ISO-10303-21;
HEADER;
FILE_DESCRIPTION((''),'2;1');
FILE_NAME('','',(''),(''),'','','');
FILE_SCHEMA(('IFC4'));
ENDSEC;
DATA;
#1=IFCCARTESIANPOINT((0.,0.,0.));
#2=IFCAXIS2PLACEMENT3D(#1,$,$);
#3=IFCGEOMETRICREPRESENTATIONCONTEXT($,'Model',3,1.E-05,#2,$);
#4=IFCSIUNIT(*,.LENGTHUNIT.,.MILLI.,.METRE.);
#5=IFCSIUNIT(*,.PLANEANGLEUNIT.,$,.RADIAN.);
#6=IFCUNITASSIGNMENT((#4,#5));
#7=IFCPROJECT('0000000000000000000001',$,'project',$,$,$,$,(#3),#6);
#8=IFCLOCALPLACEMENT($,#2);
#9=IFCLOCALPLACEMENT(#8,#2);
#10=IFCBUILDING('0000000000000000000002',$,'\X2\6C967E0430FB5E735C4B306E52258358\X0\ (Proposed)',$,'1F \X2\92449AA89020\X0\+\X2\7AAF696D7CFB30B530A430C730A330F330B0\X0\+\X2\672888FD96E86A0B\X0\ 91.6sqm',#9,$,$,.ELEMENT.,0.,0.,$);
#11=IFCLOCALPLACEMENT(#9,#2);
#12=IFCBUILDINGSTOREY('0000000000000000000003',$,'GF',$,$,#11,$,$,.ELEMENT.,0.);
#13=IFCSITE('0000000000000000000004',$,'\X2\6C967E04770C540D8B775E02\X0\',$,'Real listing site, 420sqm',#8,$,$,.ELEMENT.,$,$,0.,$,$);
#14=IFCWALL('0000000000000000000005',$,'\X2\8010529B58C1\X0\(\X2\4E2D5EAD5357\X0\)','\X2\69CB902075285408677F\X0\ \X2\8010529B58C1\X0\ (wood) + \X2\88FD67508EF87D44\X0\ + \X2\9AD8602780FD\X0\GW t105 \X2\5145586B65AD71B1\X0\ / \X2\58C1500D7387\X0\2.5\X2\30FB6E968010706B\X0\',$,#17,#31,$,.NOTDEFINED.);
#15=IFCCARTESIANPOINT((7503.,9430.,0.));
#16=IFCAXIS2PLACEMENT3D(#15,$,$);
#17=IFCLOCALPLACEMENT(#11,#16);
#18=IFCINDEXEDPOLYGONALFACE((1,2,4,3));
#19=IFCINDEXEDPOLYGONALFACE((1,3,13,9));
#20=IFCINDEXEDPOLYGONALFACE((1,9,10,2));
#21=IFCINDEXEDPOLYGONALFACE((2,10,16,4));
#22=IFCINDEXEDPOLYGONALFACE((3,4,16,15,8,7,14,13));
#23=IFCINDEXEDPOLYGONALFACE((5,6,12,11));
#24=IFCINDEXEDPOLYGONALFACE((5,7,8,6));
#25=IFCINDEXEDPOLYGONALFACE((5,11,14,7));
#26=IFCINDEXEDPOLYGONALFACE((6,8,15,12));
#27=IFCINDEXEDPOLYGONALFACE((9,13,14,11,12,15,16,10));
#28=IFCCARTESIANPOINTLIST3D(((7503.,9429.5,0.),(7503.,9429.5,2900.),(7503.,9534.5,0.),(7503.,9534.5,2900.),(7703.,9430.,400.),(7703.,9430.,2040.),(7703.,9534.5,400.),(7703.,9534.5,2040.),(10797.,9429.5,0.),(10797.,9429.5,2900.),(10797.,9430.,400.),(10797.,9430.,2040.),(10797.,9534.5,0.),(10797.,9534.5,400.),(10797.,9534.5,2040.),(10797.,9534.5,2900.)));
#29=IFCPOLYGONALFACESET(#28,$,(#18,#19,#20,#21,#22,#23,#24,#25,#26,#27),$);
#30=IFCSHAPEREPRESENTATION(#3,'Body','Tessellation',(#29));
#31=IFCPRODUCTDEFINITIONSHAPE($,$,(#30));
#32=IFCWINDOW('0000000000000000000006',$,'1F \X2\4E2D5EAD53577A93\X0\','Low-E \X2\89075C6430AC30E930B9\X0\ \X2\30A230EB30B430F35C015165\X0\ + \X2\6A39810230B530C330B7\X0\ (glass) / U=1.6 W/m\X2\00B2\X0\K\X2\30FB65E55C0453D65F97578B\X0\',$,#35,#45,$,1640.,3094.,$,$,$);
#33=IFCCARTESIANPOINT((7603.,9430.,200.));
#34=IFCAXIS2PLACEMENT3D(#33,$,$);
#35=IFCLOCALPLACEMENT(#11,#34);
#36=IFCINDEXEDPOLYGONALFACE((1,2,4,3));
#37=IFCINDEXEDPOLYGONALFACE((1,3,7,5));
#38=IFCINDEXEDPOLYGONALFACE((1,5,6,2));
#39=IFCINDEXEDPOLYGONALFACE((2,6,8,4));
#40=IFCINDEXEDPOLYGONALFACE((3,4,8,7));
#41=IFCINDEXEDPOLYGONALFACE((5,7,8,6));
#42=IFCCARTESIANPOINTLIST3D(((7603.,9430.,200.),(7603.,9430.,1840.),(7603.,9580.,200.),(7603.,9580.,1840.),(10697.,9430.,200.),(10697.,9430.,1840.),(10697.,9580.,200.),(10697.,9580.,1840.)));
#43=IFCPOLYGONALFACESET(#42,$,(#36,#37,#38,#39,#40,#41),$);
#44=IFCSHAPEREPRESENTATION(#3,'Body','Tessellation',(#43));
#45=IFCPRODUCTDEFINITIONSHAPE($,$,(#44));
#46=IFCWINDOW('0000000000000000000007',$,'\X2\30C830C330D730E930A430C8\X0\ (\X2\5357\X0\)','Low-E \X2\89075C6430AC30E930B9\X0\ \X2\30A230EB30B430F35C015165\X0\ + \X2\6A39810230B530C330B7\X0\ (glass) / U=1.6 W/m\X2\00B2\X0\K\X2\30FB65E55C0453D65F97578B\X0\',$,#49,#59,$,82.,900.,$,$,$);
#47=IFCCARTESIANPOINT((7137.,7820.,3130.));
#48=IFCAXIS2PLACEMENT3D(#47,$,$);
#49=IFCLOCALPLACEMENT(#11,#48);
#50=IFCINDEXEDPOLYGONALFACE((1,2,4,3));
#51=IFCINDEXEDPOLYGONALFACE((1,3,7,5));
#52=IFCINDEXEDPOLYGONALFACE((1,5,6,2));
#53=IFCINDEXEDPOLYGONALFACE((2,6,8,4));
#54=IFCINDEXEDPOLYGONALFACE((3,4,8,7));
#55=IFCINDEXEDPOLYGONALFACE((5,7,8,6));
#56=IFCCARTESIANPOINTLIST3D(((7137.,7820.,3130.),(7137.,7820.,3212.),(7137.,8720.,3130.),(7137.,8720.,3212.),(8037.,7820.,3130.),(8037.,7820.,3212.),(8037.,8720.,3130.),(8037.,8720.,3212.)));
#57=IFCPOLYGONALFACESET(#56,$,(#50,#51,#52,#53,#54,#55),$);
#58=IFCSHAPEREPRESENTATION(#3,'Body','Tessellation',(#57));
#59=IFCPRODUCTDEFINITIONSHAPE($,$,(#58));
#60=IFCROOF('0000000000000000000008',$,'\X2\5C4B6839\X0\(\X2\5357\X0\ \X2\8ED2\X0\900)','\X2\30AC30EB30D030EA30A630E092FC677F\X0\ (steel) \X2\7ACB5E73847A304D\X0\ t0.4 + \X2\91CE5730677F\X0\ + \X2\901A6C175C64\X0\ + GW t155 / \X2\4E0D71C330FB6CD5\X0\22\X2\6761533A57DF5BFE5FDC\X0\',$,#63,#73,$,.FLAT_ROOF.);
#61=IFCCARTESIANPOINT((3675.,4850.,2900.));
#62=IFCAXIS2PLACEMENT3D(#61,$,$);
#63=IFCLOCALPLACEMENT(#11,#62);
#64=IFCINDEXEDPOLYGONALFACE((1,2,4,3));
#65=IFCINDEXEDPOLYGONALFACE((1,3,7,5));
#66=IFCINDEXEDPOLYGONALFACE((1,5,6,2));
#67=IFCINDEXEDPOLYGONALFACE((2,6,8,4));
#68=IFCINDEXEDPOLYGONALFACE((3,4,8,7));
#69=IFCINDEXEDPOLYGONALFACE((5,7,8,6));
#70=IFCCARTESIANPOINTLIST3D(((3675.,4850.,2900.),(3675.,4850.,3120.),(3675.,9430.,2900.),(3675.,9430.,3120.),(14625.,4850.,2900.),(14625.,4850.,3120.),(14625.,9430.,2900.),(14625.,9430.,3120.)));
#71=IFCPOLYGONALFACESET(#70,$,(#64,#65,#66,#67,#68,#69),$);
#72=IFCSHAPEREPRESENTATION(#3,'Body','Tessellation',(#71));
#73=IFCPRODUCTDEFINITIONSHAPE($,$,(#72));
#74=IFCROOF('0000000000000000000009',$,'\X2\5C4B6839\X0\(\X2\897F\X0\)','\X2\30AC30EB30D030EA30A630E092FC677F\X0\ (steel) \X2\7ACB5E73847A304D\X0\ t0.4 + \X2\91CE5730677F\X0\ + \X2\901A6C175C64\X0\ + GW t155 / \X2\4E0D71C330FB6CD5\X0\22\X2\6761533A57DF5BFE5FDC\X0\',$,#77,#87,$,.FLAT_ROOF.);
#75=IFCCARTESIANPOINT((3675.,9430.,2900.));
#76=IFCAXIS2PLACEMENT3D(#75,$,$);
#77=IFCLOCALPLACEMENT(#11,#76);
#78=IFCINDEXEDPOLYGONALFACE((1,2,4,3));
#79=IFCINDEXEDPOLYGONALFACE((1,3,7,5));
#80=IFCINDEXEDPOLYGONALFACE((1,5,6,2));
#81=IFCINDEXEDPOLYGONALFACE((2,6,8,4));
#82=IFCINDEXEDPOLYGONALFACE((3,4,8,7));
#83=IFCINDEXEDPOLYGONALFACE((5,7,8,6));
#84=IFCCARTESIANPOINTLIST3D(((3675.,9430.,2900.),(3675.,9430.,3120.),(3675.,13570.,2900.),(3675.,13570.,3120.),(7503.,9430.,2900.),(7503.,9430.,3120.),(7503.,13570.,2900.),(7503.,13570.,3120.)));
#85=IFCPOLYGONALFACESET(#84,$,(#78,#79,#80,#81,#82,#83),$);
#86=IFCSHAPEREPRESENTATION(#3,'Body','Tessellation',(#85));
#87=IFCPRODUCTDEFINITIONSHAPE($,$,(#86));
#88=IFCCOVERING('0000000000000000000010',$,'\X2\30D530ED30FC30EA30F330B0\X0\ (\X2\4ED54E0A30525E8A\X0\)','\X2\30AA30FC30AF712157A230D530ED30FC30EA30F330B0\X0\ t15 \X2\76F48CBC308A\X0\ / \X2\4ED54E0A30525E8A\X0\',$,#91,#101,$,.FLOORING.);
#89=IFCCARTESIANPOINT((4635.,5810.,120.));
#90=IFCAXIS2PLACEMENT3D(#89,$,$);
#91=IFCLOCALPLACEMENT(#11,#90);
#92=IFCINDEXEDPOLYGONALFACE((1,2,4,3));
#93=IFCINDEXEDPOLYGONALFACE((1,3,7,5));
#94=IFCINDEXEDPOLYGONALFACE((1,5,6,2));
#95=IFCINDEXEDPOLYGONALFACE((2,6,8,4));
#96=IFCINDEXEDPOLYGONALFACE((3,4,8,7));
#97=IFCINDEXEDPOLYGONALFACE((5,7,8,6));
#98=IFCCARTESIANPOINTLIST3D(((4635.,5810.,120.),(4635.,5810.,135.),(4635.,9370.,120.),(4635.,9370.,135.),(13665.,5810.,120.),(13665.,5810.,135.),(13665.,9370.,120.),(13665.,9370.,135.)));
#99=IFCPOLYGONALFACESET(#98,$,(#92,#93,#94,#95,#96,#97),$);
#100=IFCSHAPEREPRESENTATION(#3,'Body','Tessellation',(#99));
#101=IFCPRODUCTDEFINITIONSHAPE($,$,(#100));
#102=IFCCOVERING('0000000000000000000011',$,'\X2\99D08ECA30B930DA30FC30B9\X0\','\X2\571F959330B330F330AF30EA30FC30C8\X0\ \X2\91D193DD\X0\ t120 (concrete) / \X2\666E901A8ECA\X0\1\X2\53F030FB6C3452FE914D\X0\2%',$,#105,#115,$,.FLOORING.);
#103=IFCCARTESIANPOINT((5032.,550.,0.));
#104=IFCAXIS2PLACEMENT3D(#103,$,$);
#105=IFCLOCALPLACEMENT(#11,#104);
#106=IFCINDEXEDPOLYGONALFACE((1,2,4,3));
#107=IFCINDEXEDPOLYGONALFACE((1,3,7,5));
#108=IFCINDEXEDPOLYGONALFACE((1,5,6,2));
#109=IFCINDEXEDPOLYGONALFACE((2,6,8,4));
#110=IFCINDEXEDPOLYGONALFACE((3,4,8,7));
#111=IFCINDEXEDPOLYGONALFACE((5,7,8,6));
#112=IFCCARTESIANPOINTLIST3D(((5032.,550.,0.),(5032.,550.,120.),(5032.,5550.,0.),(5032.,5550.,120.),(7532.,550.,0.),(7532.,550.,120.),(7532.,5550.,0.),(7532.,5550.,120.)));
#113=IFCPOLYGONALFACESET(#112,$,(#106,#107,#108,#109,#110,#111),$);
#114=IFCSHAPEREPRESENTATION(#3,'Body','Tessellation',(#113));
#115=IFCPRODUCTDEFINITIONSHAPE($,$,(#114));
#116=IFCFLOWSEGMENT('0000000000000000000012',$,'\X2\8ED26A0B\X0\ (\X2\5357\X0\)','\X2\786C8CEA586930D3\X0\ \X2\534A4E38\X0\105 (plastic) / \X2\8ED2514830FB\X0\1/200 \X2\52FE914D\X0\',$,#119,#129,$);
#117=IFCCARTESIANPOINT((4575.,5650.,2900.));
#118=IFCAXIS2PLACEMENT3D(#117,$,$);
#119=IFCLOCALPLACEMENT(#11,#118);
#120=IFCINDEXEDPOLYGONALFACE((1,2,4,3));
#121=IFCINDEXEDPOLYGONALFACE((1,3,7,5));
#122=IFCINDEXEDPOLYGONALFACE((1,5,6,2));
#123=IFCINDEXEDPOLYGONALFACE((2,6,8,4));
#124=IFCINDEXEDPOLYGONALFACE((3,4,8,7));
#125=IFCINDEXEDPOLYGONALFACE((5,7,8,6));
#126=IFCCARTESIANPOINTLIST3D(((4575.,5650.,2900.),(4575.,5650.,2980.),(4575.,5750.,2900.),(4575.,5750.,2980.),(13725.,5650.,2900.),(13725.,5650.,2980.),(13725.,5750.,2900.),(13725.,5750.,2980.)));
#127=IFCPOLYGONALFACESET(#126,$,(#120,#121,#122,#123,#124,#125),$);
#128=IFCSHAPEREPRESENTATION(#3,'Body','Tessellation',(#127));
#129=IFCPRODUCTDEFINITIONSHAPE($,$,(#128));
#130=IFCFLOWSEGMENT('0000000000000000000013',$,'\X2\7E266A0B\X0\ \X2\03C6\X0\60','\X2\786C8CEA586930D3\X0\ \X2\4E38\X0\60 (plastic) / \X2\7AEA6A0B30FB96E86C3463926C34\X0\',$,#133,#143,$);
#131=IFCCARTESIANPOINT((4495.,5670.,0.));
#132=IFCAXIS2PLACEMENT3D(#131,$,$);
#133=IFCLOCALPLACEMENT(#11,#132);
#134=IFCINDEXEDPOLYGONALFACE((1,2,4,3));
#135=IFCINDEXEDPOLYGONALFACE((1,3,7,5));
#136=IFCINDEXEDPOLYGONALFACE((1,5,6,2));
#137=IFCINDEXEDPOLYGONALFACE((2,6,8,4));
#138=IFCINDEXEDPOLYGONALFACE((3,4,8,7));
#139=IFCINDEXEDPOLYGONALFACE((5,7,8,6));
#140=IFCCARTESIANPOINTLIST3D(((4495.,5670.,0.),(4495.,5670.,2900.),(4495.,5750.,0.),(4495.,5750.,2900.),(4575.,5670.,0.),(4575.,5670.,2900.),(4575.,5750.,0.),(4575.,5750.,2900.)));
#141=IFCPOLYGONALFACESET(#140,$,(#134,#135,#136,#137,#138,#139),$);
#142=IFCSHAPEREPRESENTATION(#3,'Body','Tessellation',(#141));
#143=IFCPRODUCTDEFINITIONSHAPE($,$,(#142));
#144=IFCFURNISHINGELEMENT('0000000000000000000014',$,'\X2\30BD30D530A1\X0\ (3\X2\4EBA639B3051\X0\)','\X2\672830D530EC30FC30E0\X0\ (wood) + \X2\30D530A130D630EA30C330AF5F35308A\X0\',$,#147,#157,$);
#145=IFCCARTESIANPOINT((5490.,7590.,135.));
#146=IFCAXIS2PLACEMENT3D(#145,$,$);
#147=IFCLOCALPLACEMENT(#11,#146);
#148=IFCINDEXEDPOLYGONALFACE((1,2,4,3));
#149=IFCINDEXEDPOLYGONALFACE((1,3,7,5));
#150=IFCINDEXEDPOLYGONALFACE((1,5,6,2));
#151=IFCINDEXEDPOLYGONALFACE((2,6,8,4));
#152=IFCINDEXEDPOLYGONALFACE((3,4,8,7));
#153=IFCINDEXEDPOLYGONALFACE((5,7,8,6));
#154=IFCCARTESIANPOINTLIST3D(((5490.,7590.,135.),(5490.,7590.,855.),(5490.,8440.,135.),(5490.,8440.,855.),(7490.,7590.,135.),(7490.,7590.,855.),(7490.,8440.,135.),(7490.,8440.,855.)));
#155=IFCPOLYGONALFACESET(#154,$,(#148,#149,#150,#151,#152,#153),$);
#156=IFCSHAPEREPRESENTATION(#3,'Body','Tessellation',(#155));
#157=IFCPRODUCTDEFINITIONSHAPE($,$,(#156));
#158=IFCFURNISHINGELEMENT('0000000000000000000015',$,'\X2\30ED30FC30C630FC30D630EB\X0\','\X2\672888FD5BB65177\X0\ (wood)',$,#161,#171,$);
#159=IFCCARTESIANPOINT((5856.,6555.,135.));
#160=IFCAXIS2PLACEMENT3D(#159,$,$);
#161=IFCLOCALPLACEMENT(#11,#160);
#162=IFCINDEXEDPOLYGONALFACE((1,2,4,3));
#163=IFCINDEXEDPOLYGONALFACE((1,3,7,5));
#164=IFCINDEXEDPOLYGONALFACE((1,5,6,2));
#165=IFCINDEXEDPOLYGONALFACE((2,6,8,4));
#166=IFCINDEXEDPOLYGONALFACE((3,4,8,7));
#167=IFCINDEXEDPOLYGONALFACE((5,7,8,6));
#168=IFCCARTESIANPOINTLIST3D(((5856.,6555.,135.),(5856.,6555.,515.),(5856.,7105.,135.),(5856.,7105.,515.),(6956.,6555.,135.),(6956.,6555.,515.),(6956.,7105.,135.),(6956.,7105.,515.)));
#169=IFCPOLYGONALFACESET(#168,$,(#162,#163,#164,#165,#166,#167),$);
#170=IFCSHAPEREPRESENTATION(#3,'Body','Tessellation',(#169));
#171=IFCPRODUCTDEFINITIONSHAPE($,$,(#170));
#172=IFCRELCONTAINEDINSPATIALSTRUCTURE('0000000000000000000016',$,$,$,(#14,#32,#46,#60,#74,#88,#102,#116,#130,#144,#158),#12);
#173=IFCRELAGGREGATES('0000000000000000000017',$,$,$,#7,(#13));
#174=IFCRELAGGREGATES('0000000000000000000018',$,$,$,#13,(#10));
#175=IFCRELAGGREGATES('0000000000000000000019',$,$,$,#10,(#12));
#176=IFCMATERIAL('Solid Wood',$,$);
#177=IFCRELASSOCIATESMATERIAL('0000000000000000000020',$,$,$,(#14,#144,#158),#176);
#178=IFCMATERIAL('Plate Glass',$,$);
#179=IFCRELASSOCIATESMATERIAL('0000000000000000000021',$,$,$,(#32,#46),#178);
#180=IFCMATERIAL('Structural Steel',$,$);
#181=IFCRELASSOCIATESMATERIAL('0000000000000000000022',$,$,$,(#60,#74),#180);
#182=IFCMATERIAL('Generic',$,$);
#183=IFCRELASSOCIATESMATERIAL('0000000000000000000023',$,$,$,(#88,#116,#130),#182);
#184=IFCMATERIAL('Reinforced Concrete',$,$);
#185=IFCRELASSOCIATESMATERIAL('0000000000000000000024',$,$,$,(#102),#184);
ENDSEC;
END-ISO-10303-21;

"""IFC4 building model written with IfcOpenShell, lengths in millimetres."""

from ifc_helpers import new_model, si_unit, frame, frame_2d, origin, place, context, project, spatial, rectangle, extrude, material, element, fill, save


model = new_model("IFC4")

# Units and contexts
model_context = context("Model", 3, precision=1e-05, world=origin())
ifc_project = project(units=[si_unit("LENGTHUNIT", "METRE", prefix="MILLI"), si_unit("PLANEANGLEUNIT", "RADIAN")], contexts=[model_context])

# Site, building, storey
site_placement = place(None, origin())
site = spatial("IfcSite", under=ifc_project, at=site_placement, Name="沖縄県名護市", ObjectType="Real listing site, 420sqm", CompositionType="ELEMENT", RefElevation=0.0)
building_placement = place(site_placement, origin())
building = spatial("IfcBuilding", under=site, at=building_placement, Name="沖縄・平屋の別荘 (Proposed)", ObjectType="1F 鉄骨造+窯業系サイディング+木製雨樋 91.6sqm", CompositionType="ELEMENT", ElevationOfRefHeight=0.0, ElevationOfTerrain=0.0)
storey_placement = place(building_placement, origin())
storey = spatial("IfcBuildingStorey", under=building, at=storey_placement, Name="GF", CompositionType="ELEMENT", Elevation=0.0)

# Shared definitions
ifc_material_1 = material(Name="Solid Wood")

# Shared definitions
ifc_material_2 = material(Name="Reinforced Concrete")

# Shared definitions
ifc_material_3 = material(Name="Plate Glass")

# Wall, opening, window
wall_1_placement = place(storey_placement, frame((7503.0, 9430.0, 0.0)))
wall_1 = element("IfcWall", 1, at=wall_1_placement, inside=storey, material=ifc_material_1, Name="耐力壁(中庭南)", Description="構造用合板 耐力壁 (wood) + 製材軸組 + 高性能GW t105 充填断熱 / 壁倍率2.5・準耐火", PredefinedType="NOTDEFINED", context=model_context, shape_type="SweptSolid", body=[
    extrude(rectangle(XDim=3294.0, YDim=105.0, at=frame_2d((1647.0, 52.0))), frame((7503.0, 9430.0, 0.0)), (0.0, 0.0, 1.0), 2900.0),
])
opening_1_placement = place(storey_placement, frame((7603.0, 9430.0, 200.0)))
opening_1 = element("IfcOpeningElement", 2, at=opening_1_placement, cuts=wall_1, PredefinedType="NOTDEFINED", context=model_context, shape_type="SweptSolid", body=[
    extrude(rectangle(XDim=3094.0, YDim=150.0, at=frame_2d((1547.0, 75.0))), frame((7603.0, 9430.0, 200.0)), (0.0, 0.0, 1.0), 1640.0),
])
window_1_placement = place(storey_placement, frame((7603.0, 9430.0, 200.0)))
window_1 = element("IfcWindow", 3, at=window_1_placement, inside=storey, material=ifc_material_3, Name="1F 中庭南窓", Description="Low-E 複層ガラス アルゴン封入 + 樹脂サッシ (glass) / U=1.6 W/m²K・日射取得型", OverallHeight=1640.0, OverallWidth=3094.0, context=model_context, shape_type="SweptSolid", body=[
    extrude(rectangle(XDim=3094.0, YDim=150.0, at=frame_2d((1547.0, 75.0))), frame((7603.0, 9430.0, 200.0)), (0.0, 0.0, 1.0), 1640.0),
])
fill(opening_1, window_1)

# Window
window_2_placement = place(storey_placement, frame((7137.0, 7820.0, 3130.0)))
element("IfcWindow", 4, at=window_2_placement, inside=storey, material=ifc_material_3, Name="トップライト (南)", Description="Low-E 複層ガラス アルゴン封入 + 樹脂サッシ (glass) / U=1.6 W/m²K・日射取得型", OverallHeight=82.0, OverallWidth=900.0, context=model_context, shape_type="SweptSolid", body=[
    extrude(rectangle(XDim=900.0, YDim=900.0, at=frame_2d((450.0, 450.0))), frame((7137.0, 7820.0, 3130.0)), (0.0, 0.0, 1.0), 82.0),
])

# Roofs
ifc_material_4 = material(Name="Structural Steel")
roof_1_placement = place(storey_placement, frame((3675.0, 4850.0, 2900.0)))
element("IfcRoof", 5, at=roof_1_placement, inside=storey, material=ifc_material_4, Name="屋根(南 軒900)", Description="ガルバリウム鋼板 (steel) 立平葺き t0.4 + 野地板 + 通気層 + GW t155 / 不燃・法22条区域対応", PredefinedType="FLAT_ROOF", context=model_context, shape_type="SweptSolid", body=[
    extrude(rectangle(XDim=10950.0, YDim=4580.0, at=frame_2d((5475.0, 2290.0))), frame((3675.0, 4850.0, 2900.0)), (0.0, 0.0, 1.0), 220.0),
])
roof_2_placement = place(storey_placement, frame((3675.0, 9430.0, 2900.0)))
element("IfcRoof", 6, at=roof_2_placement, inside=storey, material=ifc_material_4, Name="屋根(西)", Description="ガルバリウム鋼板 (steel) 立平葺き t0.4 + 野地板 + 通気層 + GW t155 / 不燃・法22条区域対応", PredefinedType="FLAT_ROOF", context=model_context, shape_type="SweptSolid", body=[
    extrude(rectangle(XDim=3828.0, YDim=4140.0, at=frame_2d((1914.0, 2070.0))), frame((3675.0, 9430.0, 2900.0)), (0.0, 0.0, 1.0), 220.0),
])

# Coverings
ifc_material_5 = material(Name="Generic")
covering_1_placement = place(storey_placement, frame((4635.0, 5810.0, 120.0)))
element("IfcCovering", 7, at=covering_1_placement, inside=storey, material=ifc_material_5, Name="フローリング (仕上げ床)", Description="オーク無垢フローリング t15 直貼り / 仕上げ床", PredefinedType="FLOORING", context=model_context, shape_type="SweptSolid", body=[
    extrude(rectangle(XDim=9030.0, YDim=3560.0, at=frame_2d((4515.0, 1780.0))), frame((4635.0, 5810.0, 120.0)), (0.0, 0.0, 1.0), 15.0),
])
covering_2_placement = place(storey_placement, frame((5032.0, 550.0, 0.0)))
element("IfcCovering", 8, at=covering_2_placement, inside=storey, material=ifc_material_2, Name="駐車スペース", Description="土間コンクリート 金鏝 t120 (concrete) / 普通車1台・水勾配2%", PredefinedType="FLOORING", context=model_context, shape_type="SweptSolid", body=[
    extrude(rectangle(XDim=2500.0, YDim=5000.0, at=frame_2d((1250.0, 2500.0))), frame((5032.0, 550.0, 0.0)), (0.0, 0.0, 1.0), 120.0),
])

# Flow segments
flow_segment_1_placement = place(storey_placement, frame((4575.0, 5650.0, 2900.0)))
element("IfcFlowSegment", 9, at=flow_segment_1_placement, inside=storey, material=ifc_material_5, Name="軒樋 (南)", Description="硬質塩ビ 半丸105 (plastic) / 軒先・1/200 勾配", context=model_context, shape_type="SweptSolid", body=[
    extrude(rectangle(XDim=9150.0, YDim=100.0, at=frame_2d((4575.0, 50.0))), frame((4575.0, 5650.0, 2900.0)), (0.0, 0.0, 1.0), 80.0),
])
flow_segment_2_placement = place(storey_placement, frame((4495.0, 5670.0, 0.0)))
element("IfcFlowSegment", 10, at=flow_segment_2_placement, inside=storey, material=ifc_material_5, Name="縦樋 φ60", Description="硬質塩ビ 丸60 (plastic) / 竪樋・雨水排水", context=model_context, shape_type="SweptSolid", body=[
    extrude(rectangle(XDim=80.0, YDim=80.0, at=frame_2d((40.0, 40.0))), frame((4495.0, 5670.0, 0.0)), (0.0, 0.0, 1.0), 2900.0),
])

# Furnishing elements
furnishing_1_placement = place(storey_placement, frame((5490.0, 7590.0, 135.0)))
element("IfcFurnishingElement", 11, at=furnishing_1_placement, inside=storey, material=ifc_material_1, Name="ソファ (3人掛け)", Description="木フレーム (wood) + ファブリック張り", context=model_context, shape_type="SweptSolid", body=[
    extrude(rectangle(XDim=2000.0, YDim=850.0, at=frame_2d((1000.0, 425.0))), frame((5490.0, 7590.0, 135.0)), (0.0, 0.0, 1.0), 720.0),
])
furnishing_2_placement = place(storey_placement, frame((5856.0, 6555.0, 135.0)))
element("IfcFurnishingElement", 12, at=furnishing_2_placement, inside=storey, material=ifc_material_1, Name="ローテーブル", Description="木製家具 (wood)", context=model_context, shape_type="SweptSolid", body=[
    extrude(rectangle(XDim=1100.0, YDim=550.0, at=frame_2d((550.0, 275.0))), frame((5856.0, 6555.0, 135.0)), (0.0, 0.0, 1.0), 380.0),
])

save(model, "model.ifc")
